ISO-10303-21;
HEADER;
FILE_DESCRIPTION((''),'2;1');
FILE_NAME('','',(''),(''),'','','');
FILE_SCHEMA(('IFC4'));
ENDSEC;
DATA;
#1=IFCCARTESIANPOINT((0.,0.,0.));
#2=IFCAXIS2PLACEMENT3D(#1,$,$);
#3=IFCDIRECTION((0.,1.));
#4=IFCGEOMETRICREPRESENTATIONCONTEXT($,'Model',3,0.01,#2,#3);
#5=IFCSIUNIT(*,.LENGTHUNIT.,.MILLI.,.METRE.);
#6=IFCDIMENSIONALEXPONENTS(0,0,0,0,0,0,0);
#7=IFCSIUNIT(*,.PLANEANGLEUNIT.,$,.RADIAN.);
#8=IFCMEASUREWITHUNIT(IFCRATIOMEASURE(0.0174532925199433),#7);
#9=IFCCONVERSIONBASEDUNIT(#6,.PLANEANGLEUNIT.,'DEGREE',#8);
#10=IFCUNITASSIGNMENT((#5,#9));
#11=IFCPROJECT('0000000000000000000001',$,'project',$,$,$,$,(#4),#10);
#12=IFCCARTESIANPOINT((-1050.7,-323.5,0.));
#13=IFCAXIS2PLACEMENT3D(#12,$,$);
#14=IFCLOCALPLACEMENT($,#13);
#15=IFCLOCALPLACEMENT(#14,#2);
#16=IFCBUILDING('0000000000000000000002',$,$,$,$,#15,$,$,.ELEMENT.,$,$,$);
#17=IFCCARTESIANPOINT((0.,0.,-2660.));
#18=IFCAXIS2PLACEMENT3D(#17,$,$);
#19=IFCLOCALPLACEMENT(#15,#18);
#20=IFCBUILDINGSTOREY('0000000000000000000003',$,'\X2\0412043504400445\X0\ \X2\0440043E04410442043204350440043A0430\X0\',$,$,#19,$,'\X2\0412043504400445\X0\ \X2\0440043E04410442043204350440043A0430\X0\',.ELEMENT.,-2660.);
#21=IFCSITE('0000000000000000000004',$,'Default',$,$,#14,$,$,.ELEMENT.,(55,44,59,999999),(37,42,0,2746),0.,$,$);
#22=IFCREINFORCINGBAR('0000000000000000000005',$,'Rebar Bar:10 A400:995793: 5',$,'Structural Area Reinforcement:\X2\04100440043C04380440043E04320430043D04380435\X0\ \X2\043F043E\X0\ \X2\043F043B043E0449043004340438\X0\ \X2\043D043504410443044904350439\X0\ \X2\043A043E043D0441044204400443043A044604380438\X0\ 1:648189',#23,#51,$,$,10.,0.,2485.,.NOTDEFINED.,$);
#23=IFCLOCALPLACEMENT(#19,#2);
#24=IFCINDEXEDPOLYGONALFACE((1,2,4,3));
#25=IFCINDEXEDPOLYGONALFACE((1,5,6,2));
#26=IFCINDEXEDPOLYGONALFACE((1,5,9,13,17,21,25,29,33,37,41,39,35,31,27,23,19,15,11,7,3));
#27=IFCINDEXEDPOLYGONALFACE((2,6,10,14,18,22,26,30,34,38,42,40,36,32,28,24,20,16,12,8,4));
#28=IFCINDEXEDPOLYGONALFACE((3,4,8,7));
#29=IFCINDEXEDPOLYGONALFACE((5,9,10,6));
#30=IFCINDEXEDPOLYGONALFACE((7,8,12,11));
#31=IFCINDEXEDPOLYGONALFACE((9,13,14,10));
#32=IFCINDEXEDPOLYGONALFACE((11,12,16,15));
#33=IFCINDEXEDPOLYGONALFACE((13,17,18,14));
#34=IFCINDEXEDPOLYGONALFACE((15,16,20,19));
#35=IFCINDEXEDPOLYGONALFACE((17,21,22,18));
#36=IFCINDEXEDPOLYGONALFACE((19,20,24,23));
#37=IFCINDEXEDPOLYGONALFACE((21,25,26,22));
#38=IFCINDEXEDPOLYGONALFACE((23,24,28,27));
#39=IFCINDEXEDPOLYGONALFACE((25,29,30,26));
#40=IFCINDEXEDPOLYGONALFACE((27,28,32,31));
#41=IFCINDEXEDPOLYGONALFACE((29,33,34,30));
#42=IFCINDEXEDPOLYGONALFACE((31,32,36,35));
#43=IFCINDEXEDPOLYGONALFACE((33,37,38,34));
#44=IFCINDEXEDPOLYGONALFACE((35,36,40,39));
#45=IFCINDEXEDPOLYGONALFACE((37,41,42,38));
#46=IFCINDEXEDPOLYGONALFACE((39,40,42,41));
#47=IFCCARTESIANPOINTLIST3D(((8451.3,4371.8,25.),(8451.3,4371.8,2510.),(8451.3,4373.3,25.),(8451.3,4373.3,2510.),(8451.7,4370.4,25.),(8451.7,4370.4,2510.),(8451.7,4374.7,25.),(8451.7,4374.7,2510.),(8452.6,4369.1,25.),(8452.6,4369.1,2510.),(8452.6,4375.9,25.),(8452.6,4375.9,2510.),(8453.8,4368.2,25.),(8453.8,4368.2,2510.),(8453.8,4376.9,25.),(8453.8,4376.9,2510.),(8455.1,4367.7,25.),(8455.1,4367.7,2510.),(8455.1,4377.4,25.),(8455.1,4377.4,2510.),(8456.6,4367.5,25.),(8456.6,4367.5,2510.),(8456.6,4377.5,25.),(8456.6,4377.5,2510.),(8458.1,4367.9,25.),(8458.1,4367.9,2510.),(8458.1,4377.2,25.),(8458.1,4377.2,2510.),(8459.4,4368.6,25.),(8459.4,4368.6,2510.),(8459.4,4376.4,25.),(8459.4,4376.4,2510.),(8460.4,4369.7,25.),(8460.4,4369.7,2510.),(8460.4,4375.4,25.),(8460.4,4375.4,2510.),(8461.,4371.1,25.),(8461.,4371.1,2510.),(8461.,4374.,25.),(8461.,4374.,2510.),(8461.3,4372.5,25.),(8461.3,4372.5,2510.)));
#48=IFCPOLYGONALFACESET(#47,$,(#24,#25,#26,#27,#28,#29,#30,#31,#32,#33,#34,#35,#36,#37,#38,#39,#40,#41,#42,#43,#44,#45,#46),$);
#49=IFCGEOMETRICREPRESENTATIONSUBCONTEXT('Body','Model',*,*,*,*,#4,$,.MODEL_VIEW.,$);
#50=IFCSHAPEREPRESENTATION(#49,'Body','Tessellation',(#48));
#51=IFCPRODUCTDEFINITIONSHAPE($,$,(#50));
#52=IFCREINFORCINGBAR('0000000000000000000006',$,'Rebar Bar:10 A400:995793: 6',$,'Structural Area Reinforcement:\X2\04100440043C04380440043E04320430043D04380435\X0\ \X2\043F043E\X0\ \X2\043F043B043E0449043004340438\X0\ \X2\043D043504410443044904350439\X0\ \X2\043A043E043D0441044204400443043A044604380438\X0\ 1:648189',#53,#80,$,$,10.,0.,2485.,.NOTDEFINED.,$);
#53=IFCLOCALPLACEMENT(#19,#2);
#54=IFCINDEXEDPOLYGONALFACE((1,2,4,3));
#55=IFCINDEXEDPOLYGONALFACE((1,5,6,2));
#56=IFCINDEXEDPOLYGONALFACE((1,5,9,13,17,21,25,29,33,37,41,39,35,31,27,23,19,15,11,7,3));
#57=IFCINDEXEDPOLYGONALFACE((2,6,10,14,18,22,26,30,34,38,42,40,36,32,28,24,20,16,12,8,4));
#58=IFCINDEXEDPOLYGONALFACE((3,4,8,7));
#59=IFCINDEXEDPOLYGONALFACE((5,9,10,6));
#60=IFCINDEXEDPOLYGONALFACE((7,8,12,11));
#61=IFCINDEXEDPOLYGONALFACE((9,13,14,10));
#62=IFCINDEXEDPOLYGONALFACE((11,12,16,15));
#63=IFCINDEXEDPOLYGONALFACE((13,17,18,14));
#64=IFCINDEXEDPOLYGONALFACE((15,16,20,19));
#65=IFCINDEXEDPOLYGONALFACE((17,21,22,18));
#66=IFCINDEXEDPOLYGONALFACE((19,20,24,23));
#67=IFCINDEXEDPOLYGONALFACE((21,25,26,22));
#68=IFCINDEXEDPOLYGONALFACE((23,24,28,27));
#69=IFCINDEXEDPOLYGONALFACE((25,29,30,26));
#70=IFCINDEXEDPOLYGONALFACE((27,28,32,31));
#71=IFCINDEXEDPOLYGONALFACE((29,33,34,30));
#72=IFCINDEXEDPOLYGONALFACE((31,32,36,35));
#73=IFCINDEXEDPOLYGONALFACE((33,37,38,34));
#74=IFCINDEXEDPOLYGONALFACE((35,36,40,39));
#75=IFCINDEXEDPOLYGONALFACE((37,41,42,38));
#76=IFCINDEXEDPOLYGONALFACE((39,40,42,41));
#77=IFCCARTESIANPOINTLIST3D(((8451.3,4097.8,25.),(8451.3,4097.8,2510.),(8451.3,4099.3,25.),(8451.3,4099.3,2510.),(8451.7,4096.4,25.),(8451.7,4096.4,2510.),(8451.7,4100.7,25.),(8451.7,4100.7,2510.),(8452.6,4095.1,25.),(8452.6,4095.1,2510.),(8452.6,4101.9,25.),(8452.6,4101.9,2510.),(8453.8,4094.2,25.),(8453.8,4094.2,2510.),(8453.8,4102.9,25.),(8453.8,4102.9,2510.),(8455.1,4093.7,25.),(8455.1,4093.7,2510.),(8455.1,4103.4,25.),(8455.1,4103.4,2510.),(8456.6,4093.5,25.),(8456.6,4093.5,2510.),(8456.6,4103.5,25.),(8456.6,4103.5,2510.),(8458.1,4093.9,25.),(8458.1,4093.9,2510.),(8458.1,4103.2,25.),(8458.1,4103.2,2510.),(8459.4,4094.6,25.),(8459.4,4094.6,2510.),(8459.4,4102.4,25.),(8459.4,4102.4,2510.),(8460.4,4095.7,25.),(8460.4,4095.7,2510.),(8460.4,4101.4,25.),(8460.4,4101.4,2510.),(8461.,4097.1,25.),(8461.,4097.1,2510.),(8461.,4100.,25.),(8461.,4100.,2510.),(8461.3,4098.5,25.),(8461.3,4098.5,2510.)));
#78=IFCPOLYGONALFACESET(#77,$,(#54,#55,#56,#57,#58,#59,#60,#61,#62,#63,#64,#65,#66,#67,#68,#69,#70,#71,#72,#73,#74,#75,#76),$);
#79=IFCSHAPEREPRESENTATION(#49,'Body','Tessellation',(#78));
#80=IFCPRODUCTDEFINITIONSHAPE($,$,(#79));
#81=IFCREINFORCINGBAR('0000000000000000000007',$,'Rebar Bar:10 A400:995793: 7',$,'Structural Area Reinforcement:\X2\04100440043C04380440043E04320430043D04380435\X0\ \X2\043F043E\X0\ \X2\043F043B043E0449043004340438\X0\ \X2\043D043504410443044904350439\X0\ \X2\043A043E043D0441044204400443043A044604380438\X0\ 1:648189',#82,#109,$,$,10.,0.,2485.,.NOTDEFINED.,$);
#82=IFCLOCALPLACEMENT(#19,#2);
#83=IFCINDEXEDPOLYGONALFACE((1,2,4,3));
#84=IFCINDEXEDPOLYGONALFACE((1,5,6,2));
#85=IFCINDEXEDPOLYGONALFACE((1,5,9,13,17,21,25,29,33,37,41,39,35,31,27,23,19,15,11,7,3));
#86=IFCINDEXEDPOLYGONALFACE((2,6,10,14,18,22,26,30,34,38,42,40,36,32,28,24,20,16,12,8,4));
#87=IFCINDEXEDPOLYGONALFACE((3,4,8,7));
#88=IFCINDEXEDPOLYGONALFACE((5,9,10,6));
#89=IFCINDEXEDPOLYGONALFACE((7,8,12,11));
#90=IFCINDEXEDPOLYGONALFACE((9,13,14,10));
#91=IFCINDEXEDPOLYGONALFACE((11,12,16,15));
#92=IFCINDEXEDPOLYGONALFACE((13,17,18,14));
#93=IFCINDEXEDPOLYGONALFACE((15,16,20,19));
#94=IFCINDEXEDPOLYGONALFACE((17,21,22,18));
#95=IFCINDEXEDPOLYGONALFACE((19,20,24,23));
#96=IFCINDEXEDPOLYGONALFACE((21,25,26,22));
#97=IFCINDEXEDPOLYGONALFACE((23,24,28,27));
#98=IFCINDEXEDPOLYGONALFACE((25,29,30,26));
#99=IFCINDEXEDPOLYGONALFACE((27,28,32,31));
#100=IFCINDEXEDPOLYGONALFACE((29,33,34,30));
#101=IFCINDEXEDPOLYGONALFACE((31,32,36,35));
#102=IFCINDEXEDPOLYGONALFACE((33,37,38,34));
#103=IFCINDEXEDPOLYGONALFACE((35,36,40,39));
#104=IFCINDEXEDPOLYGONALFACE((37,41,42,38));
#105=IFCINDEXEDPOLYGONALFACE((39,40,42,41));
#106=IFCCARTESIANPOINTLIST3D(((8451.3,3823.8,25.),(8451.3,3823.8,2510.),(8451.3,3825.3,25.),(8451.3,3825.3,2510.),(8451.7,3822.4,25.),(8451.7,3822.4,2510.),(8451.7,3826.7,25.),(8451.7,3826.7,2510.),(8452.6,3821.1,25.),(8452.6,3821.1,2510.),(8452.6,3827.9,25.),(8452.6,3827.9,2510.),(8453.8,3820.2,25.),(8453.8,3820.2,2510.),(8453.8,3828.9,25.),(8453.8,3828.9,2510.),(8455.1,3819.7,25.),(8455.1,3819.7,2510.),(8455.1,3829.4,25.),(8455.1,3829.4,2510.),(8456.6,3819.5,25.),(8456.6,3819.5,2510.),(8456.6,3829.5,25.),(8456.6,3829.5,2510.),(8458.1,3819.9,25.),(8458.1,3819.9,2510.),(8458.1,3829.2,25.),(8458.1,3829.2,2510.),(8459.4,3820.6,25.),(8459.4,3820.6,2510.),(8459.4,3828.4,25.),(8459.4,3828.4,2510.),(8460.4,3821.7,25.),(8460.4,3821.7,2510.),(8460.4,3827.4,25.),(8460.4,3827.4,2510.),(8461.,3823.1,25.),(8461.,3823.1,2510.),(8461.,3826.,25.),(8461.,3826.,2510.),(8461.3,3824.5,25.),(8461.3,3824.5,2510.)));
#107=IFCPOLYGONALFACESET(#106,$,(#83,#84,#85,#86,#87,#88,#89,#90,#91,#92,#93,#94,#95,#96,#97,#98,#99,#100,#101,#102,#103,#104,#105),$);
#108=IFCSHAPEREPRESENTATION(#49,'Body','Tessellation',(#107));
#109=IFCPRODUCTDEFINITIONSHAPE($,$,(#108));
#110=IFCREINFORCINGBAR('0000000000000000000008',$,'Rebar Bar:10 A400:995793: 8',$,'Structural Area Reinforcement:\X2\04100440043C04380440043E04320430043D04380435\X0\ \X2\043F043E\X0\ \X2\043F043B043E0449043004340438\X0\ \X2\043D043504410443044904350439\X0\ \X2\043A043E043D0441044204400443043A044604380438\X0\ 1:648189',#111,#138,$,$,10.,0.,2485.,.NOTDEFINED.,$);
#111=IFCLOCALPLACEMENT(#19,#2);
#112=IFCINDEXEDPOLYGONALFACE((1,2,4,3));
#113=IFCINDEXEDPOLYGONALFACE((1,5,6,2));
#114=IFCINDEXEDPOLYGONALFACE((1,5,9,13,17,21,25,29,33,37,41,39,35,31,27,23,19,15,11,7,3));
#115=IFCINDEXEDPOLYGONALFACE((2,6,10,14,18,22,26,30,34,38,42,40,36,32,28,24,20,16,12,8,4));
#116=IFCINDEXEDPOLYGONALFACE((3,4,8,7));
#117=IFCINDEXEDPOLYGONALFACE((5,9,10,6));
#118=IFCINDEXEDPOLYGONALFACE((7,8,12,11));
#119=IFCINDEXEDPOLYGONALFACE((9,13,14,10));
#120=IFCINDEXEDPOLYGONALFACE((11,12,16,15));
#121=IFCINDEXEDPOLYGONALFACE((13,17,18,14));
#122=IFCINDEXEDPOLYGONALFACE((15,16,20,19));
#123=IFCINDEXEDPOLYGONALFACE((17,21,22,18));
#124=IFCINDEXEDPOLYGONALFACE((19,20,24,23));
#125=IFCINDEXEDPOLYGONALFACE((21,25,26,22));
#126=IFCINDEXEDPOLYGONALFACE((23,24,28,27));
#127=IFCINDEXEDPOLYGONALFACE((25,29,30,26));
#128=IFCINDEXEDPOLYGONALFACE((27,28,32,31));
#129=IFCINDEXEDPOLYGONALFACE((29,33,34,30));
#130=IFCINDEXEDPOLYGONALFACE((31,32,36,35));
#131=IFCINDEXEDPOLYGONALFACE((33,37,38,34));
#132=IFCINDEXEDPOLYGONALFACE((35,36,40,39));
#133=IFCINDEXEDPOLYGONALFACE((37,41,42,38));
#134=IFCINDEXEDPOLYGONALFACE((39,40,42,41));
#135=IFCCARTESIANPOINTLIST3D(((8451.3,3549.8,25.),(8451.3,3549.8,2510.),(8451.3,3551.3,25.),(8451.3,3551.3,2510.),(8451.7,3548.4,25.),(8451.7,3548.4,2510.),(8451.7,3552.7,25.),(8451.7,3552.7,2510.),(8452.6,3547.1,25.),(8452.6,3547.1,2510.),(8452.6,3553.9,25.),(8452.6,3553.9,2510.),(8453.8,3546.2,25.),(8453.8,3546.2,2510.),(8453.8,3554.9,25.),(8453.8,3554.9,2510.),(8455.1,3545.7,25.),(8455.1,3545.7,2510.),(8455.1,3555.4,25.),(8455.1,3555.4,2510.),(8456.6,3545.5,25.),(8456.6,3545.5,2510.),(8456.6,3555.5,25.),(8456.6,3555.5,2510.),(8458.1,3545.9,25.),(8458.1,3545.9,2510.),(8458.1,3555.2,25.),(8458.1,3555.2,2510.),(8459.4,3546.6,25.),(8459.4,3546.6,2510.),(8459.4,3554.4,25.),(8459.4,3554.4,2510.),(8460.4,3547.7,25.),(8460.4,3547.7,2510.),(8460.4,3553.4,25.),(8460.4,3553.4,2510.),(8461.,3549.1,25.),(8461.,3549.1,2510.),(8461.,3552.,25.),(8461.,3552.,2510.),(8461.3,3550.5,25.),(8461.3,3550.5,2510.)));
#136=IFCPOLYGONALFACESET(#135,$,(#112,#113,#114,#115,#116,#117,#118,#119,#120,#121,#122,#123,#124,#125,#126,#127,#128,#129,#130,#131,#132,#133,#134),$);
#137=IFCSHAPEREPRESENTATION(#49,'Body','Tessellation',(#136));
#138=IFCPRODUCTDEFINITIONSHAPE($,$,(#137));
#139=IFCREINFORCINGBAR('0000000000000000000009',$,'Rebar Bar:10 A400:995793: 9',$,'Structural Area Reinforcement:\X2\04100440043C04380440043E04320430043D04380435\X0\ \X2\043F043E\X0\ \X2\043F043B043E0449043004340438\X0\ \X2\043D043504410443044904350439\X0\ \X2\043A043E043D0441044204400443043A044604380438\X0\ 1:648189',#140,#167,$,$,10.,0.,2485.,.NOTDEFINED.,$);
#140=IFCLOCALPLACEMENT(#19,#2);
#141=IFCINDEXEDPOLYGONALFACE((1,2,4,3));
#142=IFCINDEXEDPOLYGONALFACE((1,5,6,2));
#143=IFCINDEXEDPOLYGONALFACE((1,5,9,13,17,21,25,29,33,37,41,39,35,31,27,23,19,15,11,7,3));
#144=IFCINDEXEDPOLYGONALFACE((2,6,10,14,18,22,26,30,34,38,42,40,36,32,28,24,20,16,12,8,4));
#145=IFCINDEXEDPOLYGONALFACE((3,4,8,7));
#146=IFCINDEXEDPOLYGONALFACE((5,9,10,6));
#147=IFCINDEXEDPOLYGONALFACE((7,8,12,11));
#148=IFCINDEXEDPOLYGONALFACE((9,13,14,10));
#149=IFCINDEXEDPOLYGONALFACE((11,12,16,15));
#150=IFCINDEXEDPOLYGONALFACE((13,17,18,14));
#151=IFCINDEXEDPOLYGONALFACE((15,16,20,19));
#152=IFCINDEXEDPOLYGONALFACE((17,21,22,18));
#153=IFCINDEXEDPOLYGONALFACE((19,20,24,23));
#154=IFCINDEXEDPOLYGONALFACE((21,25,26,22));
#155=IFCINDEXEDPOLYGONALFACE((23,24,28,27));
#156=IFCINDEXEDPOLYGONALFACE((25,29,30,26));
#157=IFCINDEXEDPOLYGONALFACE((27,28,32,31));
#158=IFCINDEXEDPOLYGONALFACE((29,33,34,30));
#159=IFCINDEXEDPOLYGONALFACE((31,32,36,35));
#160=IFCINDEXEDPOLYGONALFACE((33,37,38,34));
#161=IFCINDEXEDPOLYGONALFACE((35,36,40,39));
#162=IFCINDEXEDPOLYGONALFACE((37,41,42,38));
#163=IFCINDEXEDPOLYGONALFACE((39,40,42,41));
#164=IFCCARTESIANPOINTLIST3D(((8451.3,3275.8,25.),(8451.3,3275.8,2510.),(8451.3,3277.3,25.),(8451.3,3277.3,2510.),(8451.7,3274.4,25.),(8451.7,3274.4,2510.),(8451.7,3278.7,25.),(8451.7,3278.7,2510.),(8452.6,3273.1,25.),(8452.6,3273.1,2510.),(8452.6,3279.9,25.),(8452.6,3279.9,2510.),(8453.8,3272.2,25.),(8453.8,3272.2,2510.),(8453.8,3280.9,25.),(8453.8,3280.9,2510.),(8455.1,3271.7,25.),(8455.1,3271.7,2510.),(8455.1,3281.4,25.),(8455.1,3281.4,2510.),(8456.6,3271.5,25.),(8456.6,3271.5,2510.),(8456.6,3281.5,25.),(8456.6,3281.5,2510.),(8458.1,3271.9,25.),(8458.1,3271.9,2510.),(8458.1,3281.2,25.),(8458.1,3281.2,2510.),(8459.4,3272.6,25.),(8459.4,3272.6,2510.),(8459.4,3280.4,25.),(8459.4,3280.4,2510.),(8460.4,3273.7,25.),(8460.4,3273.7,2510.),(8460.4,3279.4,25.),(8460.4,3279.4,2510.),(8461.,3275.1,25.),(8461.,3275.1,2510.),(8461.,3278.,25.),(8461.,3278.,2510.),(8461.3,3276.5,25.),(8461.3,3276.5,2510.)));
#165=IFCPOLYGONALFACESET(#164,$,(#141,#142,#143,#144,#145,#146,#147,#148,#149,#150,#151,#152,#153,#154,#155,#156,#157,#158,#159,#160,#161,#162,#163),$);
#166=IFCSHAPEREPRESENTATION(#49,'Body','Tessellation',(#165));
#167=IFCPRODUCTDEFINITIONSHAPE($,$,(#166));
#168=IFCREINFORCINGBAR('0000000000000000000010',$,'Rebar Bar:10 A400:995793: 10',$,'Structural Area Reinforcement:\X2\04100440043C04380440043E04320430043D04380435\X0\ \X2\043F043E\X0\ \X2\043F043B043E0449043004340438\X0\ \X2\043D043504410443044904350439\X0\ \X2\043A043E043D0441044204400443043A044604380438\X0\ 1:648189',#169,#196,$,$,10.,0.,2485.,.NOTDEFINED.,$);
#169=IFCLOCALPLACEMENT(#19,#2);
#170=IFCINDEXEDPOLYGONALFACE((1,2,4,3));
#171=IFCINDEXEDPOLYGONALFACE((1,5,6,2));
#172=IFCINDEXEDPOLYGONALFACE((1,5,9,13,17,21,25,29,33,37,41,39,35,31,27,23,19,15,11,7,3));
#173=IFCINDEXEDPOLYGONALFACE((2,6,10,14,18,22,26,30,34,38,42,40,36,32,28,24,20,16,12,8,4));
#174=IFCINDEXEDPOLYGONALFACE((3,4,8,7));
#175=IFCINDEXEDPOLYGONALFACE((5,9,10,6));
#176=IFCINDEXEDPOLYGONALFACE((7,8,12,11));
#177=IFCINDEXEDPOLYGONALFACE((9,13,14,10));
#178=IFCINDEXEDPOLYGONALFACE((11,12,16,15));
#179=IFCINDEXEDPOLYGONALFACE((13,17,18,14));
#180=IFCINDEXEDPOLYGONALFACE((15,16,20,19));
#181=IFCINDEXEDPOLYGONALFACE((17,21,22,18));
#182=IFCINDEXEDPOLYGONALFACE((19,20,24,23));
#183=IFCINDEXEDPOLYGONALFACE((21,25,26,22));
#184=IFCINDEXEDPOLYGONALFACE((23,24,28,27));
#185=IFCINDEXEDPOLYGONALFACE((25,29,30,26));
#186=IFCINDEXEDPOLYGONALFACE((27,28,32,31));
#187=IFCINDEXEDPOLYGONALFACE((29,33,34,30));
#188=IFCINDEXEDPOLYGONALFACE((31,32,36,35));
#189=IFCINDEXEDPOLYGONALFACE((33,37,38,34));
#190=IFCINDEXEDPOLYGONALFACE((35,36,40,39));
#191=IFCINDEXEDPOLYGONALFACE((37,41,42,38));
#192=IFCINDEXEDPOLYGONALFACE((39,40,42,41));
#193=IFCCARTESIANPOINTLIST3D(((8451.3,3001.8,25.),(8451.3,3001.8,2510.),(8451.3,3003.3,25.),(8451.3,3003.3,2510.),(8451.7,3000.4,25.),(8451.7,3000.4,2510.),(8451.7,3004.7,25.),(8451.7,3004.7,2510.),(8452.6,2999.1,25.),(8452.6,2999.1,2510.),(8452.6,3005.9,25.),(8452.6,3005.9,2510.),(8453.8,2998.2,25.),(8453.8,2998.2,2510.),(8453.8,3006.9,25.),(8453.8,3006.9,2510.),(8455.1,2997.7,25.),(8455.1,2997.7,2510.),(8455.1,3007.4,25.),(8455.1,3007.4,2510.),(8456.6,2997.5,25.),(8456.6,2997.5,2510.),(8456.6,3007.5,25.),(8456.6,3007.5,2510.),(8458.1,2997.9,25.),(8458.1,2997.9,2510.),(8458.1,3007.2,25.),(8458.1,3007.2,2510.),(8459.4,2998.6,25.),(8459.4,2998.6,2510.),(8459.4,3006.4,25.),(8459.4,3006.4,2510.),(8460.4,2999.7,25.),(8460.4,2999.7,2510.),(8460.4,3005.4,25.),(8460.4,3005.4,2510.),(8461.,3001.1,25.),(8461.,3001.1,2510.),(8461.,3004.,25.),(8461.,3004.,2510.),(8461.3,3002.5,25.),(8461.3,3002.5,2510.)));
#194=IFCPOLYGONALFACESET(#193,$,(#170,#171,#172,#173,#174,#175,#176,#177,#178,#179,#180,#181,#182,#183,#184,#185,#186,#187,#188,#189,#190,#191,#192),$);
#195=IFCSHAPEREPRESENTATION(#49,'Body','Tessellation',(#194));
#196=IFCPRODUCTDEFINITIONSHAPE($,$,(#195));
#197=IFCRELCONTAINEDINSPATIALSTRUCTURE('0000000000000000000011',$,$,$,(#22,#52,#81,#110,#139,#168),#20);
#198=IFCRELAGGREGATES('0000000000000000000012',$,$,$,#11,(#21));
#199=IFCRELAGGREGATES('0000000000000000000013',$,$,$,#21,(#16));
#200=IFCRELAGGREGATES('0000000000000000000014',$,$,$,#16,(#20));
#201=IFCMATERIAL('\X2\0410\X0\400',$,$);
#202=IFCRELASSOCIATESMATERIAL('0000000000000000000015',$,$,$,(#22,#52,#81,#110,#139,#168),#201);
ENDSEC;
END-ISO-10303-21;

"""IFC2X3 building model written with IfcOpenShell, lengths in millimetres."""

from ifc_helpers import new_model, entity, si_unit, converted_unit, direction, frame, origin, place, context, subcontext, project, spatial, material, element, save


model = new_model("IFC2X3")

# Units and contexts
model_context = context("Model", 3, precision=0.01, world=origin(), true_north=direction((0.0, 1.0)))
body_context = subcontext(model_context, "Body", "Model", "MODEL_VIEW")
ifc_project = project(units=[si_unit("LENGTHUNIT", "METRE", prefix="MILLI"), converted_unit("PLANEANGLEUNIT", "DEGREE", entity("IfcRatioMeasure", 0.0174532925199433), si_unit("PLANEANGLEUNIT", "RADIAN"), dimensions=[0, 0, 0, 0, 0, 0, 0])], contexts=[model_context])

# Site, building, storey
site_placement = place(None, frame((-1050.7, -323.5, 0.0)))
site = spatial("IfcSite", under=ifc_project, at=site_placement, Name="Default", CompositionType="ELEMENT", RefLatitude=(55, 44, 59, 999999), RefLongitude=(37, 42, 0, 2746), RefElevation=0.0)
building_placement = place(site_placement, origin())
building = spatial("IfcBuilding", under=site, at=building_placement, CompositionType="ELEMENT")
storey_placement = place(building_placement, frame((0.0, 0.0, -2660.0)))
storey = spatial("IfcBuildingStorey", under=building, at=storey_placement, Name="Верх ростверка", LongName="Верх ростверка", CompositionType="ELEMENT", Elevation=-2660.0)

# Reinforcing bars
ifc_material = material(Name="А400")
reinforcing_bar_1_placement = place(storey_placement, origin())
element("IfcReinforcingBar", 1, at=reinforcing_bar_1_placement, inside=storey, material=ifc_material, Name="Rebar Bar:10 A400:995793: 5", ObjectType="Structural Area Reinforcement:Армирование по площади несущей конструкции 1:648189", BarLength=2485.0, BarRole="NOTDEFINED", CrossSectionArea=0.0, NominalDiameter=10.0, context=body_context, shape_type="AdvancedSweptSolid", body=[
    entity("IfcSweptDiskSolid", entity("IfcCompositeCurve", [entity("IfcCompositeCurveSegment", "CONTINUOUS", True, entity("IfcPolyline", [entity("IfcCartesianPoint", [8456.3, 4372.5, 25.0]), entity("IfcCartesianPoint", [8456.3, 4372.5, 2510.0])]))], False), 5.0, None, 0.0, 1.0),
])
reinforcing_bar_2_placement = place(storey_placement, origin())
element("IfcReinforcingBar", 2, at=reinforcing_bar_2_placement, inside=storey, material=ifc_material, Name="Rebar Bar:10 A400:995793: 6", ObjectType="Structural Area Reinforcement:Армирование по площади несущей конструкции 1:648189", BarLength=2485.0, BarRole="NOTDEFINED", CrossSectionArea=0.0, NominalDiameter=10.0, context=body_context, shape_type="AdvancedSweptSolid", body=[
    entity("IfcSweptDiskSolid", entity("IfcCompositeCurve", [entity("IfcCompositeCurveSegment", "CONTINUOUS", True, entity("IfcPolyline", [entity("IfcCartesianPoint", [8456.3, 4098.5, 25.0]), entity("IfcCartesianPoint", [8456.3, 4098.5, 2510.0])]))], False), 5.0, None, 0.0, 1.0),
])
reinforcing_bar_3_placement = place(storey_placement, origin())
element("IfcReinforcingBar", 3, at=reinforcing_bar_3_placement, inside=storey, material=ifc_material, Name="Rebar Bar:10 A400:995793: 7", ObjectType="Structural Area Reinforcement:Армирование по площади несущей конструкции 1:648189", BarLength=2485.0, BarRole="NOTDEFINED", CrossSectionArea=0.0, NominalDiameter=10.0, context=body_context, shape_type="AdvancedSweptSolid", body=[
    entity("IfcSweptDiskSolid", entity("IfcCompositeCurve", [entity("IfcCompositeCurveSegment", "CONTINUOUS", True, entity("IfcPolyline", [entity("IfcCartesianPoint", [8456.3, 3824.5, 25.0]), entity("IfcCartesianPoint", [8456.3, 3824.5, 2510.0])]))], False), 5.0, None, 0.0, 1.0),
])
reinforcing_bar_4_placement = place(storey_placement, origin())
element("IfcReinforcingBar", 4, at=reinforcing_bar_4_placement, inside=storey, material=ifc_material, Name="Rebar Bar:10 A400:995793: 8", ObjectType="Structural Area Reinforcement:Армирование по площади несущей конструкции 1:648189", BarLength=2485.0, BarRole="NOTDEFINED", CrossSectionArea=0.0, NominalDiameter=10.0, context=body_context, shape_type="AdvancedSweptSolid", body=[
    entity("IfcSweptDiskSolid", entity("IfcCompositeCurve", [entity("IfcCompositeCurveSegment", "CONTINUOUS", True, entity("IfcPolyline", [entity("IfcCartesianPoint", [8456.3, 3550.5, 25.0]), entity("IfcCartesianPoint", [8456.3, 3550.5, 2510.0])]))], False), 5.0, None, 0.0, 1.0),
])
reinforcing_bar_5_placement = place(storey_placement, origin())
element("IfcReinforcingBar", 5, at=reinforcing_bar_5_placement, inside=storey, material=ifc_material, Name="Rebar Bar:10 A400:995793: 9", ObjectType="Structural Area Reinforcement:Армирование по площади несущей конструкции 1:648189", BarLength=2485.0, BarRole="NOTDEFINED", CrossSectionArea=0.0, NominalDiameter=10.0, context=body_context, shape_type="AdvancedSweptSolid", body=[
    entity("IfcSweptDiskSolid", entity("IfcCompositeCurve", [entity("IfcCompositeCurveSegment", "CONTINUOUS", True, entity("IfcPolyline", [entity("IfcCartesianPoint", [8456.3, 3276.5, 25.0]), entity("IfcCartesianPoint", [8456.3, 3276.5, 2510.0])]))], False), 5.0, None, 0.0, 1.0),
])
reinforcing_bar_6_placement = place(storey_placement, origin())
element("IfcReinforcingBar", 6, at=reinforcing_bar_6_placement, inside=storey, material=ifc_material, Name="Rebar Bar:10 A400:995793: 10", ObjectType="Structural Area Reinforcement:Армирование по площади несущей конструкции 1:648189", BarLength=2485.0, BarRole="NOTDEFINED", CrossSectionArea=0.0, NominalDiameter=10.0, context=body_context, shape_type="AdvancedSweptSolid", body=[
    entity("IfcSweptDiskSolid", entity("IfcCompositeCurve", [entity("IfcCompositeCurveSegment", "CONTINUOUS", True, entity("IfcPolyline", [entity("IfcCartesianPoint", [8456.3, 3002.5, 25.0]), entity("IfcCartesianPoint", [8456.3, 3002.5, 2510.0])]))], False), 5.0, None, 0.0, 1.0),
])

save(model, "model.ifc")
